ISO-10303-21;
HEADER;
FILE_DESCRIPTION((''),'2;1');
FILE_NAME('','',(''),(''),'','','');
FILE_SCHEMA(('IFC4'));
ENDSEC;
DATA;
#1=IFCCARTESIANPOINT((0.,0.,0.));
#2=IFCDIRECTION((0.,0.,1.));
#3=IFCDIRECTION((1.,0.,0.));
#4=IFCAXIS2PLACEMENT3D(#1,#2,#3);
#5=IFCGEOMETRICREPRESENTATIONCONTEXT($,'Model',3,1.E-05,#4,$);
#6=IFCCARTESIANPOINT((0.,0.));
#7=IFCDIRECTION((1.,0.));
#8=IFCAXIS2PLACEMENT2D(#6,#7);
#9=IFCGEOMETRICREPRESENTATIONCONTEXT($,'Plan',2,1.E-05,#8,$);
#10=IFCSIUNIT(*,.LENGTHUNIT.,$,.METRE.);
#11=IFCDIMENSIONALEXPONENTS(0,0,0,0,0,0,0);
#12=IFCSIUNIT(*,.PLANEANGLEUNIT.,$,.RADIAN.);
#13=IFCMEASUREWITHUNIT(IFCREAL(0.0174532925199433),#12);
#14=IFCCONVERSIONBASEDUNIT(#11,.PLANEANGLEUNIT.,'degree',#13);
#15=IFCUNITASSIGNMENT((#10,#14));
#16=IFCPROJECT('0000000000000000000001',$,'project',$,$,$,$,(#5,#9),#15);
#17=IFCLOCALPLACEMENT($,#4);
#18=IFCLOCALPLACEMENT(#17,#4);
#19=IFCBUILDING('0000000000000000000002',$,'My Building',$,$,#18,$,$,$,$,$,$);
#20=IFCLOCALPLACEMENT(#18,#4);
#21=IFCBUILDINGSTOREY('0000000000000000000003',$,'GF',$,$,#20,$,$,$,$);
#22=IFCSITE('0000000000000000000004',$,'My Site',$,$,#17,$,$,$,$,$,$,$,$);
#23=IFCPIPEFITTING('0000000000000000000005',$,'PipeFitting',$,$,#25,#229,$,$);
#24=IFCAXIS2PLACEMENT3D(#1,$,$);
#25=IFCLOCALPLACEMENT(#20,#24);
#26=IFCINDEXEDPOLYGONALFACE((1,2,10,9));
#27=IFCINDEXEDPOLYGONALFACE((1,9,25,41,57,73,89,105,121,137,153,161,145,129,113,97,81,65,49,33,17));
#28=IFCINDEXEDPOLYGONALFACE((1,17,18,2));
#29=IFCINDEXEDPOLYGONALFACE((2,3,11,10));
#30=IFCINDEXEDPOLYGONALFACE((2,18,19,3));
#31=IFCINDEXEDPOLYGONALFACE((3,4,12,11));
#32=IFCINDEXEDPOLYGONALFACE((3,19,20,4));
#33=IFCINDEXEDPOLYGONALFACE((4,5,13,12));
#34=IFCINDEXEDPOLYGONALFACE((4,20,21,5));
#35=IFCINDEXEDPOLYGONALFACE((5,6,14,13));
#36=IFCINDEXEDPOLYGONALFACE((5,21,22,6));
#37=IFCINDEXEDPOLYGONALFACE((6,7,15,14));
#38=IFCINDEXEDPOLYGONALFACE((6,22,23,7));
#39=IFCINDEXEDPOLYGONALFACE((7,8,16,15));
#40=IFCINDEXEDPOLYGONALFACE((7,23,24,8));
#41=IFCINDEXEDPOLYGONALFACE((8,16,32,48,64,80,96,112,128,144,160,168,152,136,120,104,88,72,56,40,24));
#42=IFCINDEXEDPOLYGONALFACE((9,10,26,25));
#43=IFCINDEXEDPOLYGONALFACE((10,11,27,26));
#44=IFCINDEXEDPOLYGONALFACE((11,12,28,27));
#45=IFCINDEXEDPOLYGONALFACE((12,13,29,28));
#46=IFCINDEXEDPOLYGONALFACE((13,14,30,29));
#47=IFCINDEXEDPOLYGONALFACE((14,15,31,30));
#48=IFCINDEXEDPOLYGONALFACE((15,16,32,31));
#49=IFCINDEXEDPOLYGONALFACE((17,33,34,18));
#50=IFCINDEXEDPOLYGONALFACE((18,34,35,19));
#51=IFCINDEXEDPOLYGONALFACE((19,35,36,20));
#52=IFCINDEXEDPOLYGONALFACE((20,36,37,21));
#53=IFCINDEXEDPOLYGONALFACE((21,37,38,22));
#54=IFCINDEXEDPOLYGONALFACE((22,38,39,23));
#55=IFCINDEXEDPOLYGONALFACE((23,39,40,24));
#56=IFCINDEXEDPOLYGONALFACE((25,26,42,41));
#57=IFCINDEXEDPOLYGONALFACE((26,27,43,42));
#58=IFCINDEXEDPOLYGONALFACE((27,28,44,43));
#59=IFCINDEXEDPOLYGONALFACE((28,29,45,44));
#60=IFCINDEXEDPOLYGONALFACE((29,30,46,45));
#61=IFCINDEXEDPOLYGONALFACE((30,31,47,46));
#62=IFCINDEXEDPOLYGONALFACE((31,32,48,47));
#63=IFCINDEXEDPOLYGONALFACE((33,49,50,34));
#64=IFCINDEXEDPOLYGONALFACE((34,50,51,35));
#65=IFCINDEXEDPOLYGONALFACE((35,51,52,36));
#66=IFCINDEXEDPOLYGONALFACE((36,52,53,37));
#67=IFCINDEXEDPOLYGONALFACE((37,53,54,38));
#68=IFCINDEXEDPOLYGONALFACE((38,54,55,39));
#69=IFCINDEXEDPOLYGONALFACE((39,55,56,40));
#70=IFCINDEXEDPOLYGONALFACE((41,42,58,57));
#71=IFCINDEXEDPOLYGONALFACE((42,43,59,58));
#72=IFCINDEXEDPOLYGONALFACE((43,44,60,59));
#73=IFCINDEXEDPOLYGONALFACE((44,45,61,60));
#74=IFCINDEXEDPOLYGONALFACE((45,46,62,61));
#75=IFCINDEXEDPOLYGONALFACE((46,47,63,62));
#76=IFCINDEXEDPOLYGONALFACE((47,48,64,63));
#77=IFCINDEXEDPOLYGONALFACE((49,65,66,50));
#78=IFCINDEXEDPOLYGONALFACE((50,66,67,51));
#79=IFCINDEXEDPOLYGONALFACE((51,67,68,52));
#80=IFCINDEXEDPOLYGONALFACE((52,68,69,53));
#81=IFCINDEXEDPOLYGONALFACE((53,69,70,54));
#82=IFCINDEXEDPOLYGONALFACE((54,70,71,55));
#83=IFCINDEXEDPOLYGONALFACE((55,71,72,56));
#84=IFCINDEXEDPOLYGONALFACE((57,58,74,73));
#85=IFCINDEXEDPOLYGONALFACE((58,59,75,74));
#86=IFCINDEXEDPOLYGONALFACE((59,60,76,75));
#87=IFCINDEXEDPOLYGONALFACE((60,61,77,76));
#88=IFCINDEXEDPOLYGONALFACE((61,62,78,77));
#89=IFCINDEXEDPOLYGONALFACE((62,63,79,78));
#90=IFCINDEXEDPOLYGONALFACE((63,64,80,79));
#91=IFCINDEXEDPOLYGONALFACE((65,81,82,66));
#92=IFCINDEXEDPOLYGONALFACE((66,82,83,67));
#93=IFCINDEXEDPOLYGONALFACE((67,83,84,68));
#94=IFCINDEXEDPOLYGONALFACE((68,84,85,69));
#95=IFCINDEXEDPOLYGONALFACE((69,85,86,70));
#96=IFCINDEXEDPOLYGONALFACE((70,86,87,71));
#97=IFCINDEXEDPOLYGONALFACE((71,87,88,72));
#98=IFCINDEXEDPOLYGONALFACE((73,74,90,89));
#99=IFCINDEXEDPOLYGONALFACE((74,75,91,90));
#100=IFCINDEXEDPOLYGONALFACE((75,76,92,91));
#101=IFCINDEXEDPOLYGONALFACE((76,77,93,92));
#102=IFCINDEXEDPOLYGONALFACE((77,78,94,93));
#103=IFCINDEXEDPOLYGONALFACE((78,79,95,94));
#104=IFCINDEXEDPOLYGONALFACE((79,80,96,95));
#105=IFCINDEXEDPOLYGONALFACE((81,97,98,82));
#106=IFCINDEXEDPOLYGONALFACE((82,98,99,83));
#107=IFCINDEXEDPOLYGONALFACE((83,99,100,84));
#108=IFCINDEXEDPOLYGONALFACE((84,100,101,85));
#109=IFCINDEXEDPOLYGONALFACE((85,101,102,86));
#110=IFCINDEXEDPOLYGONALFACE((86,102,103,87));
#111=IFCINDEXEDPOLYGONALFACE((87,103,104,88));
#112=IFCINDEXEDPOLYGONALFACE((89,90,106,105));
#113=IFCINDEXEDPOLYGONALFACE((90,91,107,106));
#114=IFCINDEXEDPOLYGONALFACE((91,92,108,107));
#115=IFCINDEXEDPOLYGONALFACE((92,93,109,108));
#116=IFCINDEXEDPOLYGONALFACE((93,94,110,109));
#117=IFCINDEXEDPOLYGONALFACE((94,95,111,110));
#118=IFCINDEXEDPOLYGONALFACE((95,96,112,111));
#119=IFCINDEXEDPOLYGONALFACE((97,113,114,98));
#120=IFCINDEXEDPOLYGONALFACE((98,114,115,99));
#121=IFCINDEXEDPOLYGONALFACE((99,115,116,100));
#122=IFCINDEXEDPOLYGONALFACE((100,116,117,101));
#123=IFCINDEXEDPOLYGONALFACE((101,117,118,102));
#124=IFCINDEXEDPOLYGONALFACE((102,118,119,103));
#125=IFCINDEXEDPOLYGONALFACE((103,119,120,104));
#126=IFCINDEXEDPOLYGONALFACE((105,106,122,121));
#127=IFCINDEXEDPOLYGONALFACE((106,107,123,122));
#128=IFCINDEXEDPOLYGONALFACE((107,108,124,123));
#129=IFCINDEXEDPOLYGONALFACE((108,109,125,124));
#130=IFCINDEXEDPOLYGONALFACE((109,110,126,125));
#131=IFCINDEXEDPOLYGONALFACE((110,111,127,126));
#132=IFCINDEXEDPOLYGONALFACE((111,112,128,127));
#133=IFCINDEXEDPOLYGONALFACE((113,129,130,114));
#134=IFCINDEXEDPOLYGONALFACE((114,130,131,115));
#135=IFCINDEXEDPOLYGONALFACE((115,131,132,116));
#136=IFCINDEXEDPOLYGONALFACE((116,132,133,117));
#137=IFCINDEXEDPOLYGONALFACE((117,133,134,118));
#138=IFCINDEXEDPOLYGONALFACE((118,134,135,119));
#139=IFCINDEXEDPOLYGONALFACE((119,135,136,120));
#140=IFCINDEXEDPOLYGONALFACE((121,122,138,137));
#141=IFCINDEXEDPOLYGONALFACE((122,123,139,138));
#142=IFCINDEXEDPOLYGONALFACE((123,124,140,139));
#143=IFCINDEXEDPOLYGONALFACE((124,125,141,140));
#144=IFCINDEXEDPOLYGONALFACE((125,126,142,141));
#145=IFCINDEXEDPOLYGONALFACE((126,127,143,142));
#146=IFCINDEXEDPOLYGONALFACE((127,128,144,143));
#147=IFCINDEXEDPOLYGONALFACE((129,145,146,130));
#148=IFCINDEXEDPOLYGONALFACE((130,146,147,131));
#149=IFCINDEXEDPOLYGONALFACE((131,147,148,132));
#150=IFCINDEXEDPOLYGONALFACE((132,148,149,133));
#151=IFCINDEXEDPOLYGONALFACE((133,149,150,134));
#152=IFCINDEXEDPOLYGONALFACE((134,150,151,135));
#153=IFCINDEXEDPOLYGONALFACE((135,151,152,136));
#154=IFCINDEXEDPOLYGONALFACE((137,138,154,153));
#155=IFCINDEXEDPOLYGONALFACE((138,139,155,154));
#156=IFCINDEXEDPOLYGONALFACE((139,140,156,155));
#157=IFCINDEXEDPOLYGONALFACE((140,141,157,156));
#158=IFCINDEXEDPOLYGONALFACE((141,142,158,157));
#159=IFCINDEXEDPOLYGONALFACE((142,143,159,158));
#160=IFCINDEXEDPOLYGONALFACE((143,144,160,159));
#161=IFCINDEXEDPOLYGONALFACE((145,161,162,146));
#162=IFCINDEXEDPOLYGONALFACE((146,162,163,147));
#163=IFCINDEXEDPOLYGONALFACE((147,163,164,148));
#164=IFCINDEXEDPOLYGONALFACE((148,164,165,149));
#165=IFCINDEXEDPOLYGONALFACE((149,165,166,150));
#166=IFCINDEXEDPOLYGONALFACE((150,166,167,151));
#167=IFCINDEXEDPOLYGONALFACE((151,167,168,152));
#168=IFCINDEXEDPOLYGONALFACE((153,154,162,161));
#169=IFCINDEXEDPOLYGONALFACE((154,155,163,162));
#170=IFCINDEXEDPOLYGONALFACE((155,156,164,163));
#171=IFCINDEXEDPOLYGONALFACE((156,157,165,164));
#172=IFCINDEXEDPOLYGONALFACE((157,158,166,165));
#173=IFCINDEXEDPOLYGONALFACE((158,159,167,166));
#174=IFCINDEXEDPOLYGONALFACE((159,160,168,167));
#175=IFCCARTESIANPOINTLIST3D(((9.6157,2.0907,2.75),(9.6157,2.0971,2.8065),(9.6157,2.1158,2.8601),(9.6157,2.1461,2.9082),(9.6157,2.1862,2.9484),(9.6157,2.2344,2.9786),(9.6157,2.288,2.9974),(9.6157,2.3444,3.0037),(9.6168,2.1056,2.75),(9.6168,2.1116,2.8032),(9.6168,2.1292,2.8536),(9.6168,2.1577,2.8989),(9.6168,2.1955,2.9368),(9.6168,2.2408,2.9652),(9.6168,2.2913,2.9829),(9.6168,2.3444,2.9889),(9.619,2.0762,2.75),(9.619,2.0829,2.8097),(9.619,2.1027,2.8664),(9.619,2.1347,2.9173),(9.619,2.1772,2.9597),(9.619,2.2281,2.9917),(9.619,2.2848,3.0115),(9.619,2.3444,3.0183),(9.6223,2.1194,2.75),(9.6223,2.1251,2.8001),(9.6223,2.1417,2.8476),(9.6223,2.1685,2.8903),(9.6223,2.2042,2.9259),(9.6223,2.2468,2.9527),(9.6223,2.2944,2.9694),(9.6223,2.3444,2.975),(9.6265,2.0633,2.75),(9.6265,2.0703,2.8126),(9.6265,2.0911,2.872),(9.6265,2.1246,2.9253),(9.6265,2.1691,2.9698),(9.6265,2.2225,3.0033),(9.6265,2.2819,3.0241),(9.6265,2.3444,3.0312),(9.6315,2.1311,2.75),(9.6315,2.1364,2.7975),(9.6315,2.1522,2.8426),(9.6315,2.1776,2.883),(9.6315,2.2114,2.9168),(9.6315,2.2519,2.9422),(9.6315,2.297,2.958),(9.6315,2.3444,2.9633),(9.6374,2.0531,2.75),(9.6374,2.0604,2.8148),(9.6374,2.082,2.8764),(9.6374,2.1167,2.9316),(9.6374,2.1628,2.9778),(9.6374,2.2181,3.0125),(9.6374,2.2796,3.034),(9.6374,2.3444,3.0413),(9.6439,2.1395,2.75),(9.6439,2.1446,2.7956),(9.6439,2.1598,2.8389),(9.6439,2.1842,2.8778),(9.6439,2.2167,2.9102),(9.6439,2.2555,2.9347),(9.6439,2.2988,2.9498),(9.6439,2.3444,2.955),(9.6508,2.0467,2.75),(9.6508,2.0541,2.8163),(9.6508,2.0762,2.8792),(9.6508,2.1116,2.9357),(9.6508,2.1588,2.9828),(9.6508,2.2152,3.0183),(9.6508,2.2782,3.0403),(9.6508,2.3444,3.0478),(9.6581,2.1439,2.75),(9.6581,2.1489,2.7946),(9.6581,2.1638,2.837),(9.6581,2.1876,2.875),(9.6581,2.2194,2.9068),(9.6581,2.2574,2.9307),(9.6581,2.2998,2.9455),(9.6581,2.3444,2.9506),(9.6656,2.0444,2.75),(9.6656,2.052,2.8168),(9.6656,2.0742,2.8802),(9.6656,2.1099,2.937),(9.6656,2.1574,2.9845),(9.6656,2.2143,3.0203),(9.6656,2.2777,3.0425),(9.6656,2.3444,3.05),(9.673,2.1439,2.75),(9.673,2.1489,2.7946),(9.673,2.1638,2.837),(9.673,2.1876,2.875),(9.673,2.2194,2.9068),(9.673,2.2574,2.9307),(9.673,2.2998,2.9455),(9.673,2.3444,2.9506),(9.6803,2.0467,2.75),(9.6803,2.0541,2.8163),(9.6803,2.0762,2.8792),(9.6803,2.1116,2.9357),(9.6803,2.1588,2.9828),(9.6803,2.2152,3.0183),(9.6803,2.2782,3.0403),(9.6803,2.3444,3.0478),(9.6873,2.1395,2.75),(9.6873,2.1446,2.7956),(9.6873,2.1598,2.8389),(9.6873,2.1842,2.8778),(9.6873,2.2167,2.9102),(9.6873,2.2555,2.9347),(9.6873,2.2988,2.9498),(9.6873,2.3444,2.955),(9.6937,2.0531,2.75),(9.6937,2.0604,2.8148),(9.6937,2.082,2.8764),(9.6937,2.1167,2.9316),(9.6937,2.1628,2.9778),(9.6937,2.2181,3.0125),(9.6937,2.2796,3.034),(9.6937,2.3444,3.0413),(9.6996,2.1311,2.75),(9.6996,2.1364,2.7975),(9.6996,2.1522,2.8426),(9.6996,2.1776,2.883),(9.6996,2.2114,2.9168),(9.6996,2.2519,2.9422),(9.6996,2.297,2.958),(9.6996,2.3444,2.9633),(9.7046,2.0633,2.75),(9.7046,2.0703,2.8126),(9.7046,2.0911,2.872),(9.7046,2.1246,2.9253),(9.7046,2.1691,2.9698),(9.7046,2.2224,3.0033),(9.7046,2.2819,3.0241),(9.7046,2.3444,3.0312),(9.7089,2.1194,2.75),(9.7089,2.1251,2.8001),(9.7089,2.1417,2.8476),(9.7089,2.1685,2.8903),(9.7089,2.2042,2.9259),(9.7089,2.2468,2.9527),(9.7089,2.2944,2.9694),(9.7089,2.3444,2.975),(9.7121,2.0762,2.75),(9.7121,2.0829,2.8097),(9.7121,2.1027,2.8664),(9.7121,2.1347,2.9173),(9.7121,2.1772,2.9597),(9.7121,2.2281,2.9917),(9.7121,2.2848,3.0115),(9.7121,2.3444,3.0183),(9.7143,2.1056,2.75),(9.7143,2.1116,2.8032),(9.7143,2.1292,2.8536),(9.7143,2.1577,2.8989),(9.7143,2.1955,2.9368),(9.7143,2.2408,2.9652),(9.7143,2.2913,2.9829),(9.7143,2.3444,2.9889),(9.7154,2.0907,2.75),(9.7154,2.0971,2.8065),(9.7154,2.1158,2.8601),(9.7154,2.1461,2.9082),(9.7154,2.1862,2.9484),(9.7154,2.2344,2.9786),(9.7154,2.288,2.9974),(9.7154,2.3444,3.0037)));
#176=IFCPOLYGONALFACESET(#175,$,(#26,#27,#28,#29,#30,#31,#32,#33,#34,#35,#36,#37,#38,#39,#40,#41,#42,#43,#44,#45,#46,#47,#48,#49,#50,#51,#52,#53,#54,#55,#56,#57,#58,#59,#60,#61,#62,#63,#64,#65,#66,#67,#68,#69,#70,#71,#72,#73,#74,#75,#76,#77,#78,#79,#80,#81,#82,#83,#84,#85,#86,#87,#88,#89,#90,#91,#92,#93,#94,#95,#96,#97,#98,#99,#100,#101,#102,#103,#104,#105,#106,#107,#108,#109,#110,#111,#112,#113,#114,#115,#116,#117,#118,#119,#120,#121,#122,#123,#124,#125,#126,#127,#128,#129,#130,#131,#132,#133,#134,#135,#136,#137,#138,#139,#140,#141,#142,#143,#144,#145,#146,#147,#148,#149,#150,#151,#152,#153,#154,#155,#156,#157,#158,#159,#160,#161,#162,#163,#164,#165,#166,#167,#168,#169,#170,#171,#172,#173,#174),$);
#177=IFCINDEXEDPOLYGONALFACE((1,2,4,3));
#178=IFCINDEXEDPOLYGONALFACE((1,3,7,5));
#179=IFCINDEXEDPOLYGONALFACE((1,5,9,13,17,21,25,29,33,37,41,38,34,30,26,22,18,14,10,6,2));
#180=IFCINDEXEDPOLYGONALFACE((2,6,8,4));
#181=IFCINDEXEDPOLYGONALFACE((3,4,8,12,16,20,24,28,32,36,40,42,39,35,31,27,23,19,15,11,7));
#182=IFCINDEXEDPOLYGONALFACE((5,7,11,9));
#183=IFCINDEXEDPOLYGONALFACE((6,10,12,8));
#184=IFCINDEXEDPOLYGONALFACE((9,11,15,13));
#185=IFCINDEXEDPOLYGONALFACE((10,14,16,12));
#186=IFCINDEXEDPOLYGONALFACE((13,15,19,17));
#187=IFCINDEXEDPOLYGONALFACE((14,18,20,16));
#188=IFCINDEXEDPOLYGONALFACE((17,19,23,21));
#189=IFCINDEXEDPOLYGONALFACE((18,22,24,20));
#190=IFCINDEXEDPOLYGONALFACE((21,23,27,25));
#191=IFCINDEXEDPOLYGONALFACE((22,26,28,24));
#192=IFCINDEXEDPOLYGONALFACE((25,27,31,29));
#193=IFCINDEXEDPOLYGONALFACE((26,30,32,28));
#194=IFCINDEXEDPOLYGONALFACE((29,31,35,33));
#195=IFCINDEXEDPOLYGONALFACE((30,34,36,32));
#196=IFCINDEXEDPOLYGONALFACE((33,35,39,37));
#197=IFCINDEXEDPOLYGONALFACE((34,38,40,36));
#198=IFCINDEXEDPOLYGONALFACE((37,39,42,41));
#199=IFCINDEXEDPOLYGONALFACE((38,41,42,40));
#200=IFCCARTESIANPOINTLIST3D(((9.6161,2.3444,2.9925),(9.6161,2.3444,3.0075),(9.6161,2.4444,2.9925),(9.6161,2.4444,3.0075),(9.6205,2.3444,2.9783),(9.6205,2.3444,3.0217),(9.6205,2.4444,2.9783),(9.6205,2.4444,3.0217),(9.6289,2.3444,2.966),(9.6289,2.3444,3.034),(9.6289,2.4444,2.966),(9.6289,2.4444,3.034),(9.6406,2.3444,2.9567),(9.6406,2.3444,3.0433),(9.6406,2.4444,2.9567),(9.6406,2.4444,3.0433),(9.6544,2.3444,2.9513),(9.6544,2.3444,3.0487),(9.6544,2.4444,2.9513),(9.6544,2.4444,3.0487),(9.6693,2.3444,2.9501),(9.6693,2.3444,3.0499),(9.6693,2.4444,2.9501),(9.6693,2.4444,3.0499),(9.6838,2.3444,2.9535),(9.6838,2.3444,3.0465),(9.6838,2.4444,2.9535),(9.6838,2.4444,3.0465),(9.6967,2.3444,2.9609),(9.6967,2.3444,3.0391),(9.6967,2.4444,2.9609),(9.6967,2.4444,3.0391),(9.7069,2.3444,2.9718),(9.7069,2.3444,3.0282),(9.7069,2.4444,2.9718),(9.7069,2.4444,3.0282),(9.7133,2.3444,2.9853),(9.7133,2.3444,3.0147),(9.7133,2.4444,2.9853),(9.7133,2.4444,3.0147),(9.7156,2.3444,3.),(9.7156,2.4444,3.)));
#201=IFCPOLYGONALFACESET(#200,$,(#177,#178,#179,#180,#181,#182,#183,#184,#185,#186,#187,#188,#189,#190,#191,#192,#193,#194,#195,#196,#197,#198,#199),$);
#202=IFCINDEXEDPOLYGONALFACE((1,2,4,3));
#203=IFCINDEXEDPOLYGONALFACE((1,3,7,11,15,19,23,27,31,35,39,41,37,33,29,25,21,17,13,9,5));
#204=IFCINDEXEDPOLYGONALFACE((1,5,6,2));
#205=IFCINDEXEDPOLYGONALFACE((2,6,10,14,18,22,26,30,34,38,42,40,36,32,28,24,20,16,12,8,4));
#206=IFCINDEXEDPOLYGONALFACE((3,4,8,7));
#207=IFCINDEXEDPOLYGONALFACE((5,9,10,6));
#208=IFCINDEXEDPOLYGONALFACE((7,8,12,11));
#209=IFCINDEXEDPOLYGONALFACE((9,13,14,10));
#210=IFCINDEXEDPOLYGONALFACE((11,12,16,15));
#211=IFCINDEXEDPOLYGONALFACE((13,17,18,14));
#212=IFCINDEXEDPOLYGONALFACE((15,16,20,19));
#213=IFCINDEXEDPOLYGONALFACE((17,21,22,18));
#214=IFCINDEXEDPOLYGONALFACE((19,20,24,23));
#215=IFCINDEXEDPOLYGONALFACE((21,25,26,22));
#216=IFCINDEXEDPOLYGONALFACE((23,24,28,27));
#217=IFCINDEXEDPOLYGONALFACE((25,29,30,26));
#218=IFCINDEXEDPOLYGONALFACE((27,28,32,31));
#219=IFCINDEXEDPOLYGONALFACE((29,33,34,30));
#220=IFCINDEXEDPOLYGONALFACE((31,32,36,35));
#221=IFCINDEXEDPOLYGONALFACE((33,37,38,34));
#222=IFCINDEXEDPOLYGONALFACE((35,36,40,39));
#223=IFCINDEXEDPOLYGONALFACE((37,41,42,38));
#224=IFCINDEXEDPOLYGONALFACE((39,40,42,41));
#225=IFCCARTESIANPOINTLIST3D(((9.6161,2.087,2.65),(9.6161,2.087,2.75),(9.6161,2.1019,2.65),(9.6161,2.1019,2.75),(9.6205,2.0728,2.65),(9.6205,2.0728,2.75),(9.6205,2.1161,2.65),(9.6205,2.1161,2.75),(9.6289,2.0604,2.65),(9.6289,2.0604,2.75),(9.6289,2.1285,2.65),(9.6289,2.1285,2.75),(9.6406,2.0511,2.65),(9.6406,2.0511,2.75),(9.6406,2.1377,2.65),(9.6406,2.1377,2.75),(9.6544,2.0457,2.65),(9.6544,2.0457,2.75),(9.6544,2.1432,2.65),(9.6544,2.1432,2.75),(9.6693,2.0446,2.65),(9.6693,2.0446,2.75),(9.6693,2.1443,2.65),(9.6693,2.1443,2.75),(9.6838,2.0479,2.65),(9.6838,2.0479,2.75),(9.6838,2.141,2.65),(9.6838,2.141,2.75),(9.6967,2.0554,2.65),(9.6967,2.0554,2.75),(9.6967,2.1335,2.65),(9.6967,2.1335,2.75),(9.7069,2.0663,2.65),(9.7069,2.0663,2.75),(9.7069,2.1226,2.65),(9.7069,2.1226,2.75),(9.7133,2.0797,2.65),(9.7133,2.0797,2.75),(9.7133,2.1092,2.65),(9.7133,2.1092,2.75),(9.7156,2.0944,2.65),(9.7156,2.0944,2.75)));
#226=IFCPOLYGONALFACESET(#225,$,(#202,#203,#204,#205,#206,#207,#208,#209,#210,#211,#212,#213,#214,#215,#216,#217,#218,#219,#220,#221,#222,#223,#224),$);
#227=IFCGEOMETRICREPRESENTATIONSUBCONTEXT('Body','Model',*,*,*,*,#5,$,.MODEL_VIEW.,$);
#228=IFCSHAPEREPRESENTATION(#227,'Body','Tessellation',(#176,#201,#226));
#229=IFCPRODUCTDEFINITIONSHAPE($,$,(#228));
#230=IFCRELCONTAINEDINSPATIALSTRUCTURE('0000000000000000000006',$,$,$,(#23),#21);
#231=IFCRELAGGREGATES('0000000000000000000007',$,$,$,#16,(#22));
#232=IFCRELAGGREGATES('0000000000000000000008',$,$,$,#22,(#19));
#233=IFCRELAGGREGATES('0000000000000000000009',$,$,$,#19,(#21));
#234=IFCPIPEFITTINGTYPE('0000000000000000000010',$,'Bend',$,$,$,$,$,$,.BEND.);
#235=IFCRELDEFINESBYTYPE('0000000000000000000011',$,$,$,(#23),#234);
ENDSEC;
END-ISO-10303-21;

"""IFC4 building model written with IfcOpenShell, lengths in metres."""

from ifc_helpers import new_model, entity, si_unit, converted_unit, frame, origin_with_axes, origin_2d_with_axis, place, context, subcontext, project, spatial, circle, extrude, source, transform, mapped, type_object, type_shapes, element, save


model = new_model("IFC4")

# Units and contexts
model_context = context("Model", 3, precision=1e-05, world=origin_with_axes())
plan_context = context("Plan", 2, precision=1e-05, world=origin_2d_with_axis())
body_context = subcontext(model_context, "Body", "Model", "MODEL_VIEW")
ifc_project = project(units=[si_unit("LENGTHUNIT", "METRE"), converted_unit("PLANEANGLEUNIT", "degree", entity("IfcReal", 0.0174532925199433), si_unit("PLANEANGLEUNIT", "RADIAN"), dimensions=[0, 0, 0, 0, 0, 0, 0])], contexts=[model_context, plan_context])

# Site, building, storey
site_placement = place(None, origin_with_axes())
site = spatial("IfcSite", under=ifc_project, at=site_placement, Name="My Site")
building_placement = place(site_placement, origin_with_axes())
building = spatial("IfcBuilding", under=site, at=building_placement, Name="My Building")
storey_placement = place(building_placement, origin_with_axes())
storey = spatial("IfcBuildingStorey", under=building, at=storey_placement, Name="GF")

# Pipe fitting
pipe_fitting_type = type_object("IfcPipeFittingType", Name="Bend", PredefinedType="BEND")
shared_shape = source(origin_with_axes(), body_context, "Body", "SolidModel", [
    entity("IfcSweptDiskSolid", entity("IfcIndexedPolyCurve", entity("IfcCartesianPointList3D", [[0.0, 0.0, 0.1], [0.0, -0.0732, 0.2768], [0.0, -0.25, 0.35]]), [entity("IfcArcIndex", [1, 2, 3])]), 0.05),
    extrude(circle(Radius=0.05), origin_with_axes(), (0.0, 0.0, 1.0), 0.1),
    extrude(circle(Radius=0.05), frame((0.0, -0.25, 0.35), z_axis=(0.0, -1.0, 0.0), x_axis=(1.0, 0.0, 0.0)), (0.0, 0.0, 1.0), 0.1),
])
type_shapes(pipe_fitting_type, [shared_shape])
for number, where, z_axis, x_axis, name in (
    (1, (9.6656, 2.4444, 3.0), (0.0, -1.0, 0.0), (1.0, 0.0, 0.0), "PipeFitting"),
):
    element("IfcPipeFitting", number, at=place(storey_placement, frame(where, z_axis=z_axis, x_axis=x_axis)), inside=storey, type_object=pipe_fitting_type, Name=name, context=body_context, shape_type="MappedRepresentation", body=[
        mapped(shared_shape, transform((0.0, 0.0, 0.0), x_axis=(1.0, 0.0, 0.0), y_axis=(0.0, 1.0, 0.0), z_axis=(0.0, 0.0, 1.0), scale=1.0)),
    ])

save(model, "model.ifc")
